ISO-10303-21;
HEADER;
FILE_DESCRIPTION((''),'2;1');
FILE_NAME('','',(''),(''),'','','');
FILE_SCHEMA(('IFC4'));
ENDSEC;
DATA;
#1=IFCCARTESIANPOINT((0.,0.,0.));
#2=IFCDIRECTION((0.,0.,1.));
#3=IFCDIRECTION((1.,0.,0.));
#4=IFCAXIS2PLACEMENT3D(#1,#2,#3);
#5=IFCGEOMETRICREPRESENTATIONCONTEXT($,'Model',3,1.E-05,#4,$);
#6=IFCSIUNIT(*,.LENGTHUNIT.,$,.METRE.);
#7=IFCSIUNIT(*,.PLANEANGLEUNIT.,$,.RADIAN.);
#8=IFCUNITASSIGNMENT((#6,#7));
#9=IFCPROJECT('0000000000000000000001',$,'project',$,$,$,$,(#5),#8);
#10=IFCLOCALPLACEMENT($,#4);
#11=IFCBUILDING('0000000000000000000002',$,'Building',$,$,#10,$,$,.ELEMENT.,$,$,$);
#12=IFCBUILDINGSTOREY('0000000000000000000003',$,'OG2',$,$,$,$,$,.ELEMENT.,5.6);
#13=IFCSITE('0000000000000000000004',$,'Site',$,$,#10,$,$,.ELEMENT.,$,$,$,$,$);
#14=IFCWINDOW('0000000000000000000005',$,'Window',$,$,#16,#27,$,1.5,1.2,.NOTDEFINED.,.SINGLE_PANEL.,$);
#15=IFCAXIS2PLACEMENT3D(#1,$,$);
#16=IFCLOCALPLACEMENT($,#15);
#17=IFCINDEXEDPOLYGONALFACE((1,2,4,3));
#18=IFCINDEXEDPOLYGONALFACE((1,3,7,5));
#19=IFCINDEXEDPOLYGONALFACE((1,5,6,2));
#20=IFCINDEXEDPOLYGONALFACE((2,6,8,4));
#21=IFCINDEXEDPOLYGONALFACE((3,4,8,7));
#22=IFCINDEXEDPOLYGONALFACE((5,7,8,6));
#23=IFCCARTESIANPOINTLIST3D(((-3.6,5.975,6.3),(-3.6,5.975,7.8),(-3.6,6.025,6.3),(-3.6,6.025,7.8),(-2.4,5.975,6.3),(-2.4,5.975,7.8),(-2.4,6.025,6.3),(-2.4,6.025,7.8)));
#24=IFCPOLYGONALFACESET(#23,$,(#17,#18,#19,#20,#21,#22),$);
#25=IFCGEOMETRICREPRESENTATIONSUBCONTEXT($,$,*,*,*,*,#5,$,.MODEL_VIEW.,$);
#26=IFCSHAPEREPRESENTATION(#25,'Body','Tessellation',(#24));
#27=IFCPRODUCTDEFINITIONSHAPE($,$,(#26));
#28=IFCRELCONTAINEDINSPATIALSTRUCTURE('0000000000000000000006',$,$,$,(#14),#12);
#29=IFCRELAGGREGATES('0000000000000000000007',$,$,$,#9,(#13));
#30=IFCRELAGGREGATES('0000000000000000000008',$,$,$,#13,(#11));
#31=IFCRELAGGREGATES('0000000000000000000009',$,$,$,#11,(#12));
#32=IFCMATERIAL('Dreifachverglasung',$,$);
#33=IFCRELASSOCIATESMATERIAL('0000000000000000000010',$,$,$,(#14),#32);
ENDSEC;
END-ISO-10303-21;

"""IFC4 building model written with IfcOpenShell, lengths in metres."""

from ifc_helpers import new_model, si_unit, frame, origin, origin_with_axes, origin_2d, place, context, subcontext, project, spatial, rectangle, extrude, material, element, save


model = new_model("IFC4")

# Units and contexts
model_context = context("Model", 3, precision=1e-05, world=origin_with_axes())
sub_context = subcontext(model_context, None, None, "MODEL_VIEW")
ifc_project = project(units=[si_unit("LENGTHUNIT", "METRE"), si_unit("PLANEANGLEUNIT", "RADIAN")], contexts=[model_context])

# Site, building, storey
placement_1 = place(None, origin_with_axes())
site = spatial("IfcSite", under=ifc_project, at=placement_1, Name="Site", CompositionType="ELEMENT")
building = spatial("IfcBuilding", under=site, at=placement_1, Name="Building", CompositionType="ELEMENT")
storey = spatial("IfcBuildingStorey", under=building, Name="OG2", CompositionType="ELEMENT", Elevation=5.6)

# Window
ifc_material = material(Name="Dreifachverglasung")
placement_2 = place(None, origin_with_axes())
window_placement = place(placement_2, frame((-3.0, 6.0, 6.3)))
element("IfcWindow", 1, at=window_placement, inside=storey, material=ifc_material, Name="Window", OverallHeight=1.5, OverallWidth=1.2, PartitioningType="SINGLE_PANEL", PredefinedType="NOTDEFINED", context=sub_context, shape_type="SweptSolid", body=[
    extrude(rectangle(XDim=1.2, YDim=0.05, at=origin_2d()), origin(), (0.0, 0.0, 1.0), 1.5),
])

save(model, "model.ifc")
